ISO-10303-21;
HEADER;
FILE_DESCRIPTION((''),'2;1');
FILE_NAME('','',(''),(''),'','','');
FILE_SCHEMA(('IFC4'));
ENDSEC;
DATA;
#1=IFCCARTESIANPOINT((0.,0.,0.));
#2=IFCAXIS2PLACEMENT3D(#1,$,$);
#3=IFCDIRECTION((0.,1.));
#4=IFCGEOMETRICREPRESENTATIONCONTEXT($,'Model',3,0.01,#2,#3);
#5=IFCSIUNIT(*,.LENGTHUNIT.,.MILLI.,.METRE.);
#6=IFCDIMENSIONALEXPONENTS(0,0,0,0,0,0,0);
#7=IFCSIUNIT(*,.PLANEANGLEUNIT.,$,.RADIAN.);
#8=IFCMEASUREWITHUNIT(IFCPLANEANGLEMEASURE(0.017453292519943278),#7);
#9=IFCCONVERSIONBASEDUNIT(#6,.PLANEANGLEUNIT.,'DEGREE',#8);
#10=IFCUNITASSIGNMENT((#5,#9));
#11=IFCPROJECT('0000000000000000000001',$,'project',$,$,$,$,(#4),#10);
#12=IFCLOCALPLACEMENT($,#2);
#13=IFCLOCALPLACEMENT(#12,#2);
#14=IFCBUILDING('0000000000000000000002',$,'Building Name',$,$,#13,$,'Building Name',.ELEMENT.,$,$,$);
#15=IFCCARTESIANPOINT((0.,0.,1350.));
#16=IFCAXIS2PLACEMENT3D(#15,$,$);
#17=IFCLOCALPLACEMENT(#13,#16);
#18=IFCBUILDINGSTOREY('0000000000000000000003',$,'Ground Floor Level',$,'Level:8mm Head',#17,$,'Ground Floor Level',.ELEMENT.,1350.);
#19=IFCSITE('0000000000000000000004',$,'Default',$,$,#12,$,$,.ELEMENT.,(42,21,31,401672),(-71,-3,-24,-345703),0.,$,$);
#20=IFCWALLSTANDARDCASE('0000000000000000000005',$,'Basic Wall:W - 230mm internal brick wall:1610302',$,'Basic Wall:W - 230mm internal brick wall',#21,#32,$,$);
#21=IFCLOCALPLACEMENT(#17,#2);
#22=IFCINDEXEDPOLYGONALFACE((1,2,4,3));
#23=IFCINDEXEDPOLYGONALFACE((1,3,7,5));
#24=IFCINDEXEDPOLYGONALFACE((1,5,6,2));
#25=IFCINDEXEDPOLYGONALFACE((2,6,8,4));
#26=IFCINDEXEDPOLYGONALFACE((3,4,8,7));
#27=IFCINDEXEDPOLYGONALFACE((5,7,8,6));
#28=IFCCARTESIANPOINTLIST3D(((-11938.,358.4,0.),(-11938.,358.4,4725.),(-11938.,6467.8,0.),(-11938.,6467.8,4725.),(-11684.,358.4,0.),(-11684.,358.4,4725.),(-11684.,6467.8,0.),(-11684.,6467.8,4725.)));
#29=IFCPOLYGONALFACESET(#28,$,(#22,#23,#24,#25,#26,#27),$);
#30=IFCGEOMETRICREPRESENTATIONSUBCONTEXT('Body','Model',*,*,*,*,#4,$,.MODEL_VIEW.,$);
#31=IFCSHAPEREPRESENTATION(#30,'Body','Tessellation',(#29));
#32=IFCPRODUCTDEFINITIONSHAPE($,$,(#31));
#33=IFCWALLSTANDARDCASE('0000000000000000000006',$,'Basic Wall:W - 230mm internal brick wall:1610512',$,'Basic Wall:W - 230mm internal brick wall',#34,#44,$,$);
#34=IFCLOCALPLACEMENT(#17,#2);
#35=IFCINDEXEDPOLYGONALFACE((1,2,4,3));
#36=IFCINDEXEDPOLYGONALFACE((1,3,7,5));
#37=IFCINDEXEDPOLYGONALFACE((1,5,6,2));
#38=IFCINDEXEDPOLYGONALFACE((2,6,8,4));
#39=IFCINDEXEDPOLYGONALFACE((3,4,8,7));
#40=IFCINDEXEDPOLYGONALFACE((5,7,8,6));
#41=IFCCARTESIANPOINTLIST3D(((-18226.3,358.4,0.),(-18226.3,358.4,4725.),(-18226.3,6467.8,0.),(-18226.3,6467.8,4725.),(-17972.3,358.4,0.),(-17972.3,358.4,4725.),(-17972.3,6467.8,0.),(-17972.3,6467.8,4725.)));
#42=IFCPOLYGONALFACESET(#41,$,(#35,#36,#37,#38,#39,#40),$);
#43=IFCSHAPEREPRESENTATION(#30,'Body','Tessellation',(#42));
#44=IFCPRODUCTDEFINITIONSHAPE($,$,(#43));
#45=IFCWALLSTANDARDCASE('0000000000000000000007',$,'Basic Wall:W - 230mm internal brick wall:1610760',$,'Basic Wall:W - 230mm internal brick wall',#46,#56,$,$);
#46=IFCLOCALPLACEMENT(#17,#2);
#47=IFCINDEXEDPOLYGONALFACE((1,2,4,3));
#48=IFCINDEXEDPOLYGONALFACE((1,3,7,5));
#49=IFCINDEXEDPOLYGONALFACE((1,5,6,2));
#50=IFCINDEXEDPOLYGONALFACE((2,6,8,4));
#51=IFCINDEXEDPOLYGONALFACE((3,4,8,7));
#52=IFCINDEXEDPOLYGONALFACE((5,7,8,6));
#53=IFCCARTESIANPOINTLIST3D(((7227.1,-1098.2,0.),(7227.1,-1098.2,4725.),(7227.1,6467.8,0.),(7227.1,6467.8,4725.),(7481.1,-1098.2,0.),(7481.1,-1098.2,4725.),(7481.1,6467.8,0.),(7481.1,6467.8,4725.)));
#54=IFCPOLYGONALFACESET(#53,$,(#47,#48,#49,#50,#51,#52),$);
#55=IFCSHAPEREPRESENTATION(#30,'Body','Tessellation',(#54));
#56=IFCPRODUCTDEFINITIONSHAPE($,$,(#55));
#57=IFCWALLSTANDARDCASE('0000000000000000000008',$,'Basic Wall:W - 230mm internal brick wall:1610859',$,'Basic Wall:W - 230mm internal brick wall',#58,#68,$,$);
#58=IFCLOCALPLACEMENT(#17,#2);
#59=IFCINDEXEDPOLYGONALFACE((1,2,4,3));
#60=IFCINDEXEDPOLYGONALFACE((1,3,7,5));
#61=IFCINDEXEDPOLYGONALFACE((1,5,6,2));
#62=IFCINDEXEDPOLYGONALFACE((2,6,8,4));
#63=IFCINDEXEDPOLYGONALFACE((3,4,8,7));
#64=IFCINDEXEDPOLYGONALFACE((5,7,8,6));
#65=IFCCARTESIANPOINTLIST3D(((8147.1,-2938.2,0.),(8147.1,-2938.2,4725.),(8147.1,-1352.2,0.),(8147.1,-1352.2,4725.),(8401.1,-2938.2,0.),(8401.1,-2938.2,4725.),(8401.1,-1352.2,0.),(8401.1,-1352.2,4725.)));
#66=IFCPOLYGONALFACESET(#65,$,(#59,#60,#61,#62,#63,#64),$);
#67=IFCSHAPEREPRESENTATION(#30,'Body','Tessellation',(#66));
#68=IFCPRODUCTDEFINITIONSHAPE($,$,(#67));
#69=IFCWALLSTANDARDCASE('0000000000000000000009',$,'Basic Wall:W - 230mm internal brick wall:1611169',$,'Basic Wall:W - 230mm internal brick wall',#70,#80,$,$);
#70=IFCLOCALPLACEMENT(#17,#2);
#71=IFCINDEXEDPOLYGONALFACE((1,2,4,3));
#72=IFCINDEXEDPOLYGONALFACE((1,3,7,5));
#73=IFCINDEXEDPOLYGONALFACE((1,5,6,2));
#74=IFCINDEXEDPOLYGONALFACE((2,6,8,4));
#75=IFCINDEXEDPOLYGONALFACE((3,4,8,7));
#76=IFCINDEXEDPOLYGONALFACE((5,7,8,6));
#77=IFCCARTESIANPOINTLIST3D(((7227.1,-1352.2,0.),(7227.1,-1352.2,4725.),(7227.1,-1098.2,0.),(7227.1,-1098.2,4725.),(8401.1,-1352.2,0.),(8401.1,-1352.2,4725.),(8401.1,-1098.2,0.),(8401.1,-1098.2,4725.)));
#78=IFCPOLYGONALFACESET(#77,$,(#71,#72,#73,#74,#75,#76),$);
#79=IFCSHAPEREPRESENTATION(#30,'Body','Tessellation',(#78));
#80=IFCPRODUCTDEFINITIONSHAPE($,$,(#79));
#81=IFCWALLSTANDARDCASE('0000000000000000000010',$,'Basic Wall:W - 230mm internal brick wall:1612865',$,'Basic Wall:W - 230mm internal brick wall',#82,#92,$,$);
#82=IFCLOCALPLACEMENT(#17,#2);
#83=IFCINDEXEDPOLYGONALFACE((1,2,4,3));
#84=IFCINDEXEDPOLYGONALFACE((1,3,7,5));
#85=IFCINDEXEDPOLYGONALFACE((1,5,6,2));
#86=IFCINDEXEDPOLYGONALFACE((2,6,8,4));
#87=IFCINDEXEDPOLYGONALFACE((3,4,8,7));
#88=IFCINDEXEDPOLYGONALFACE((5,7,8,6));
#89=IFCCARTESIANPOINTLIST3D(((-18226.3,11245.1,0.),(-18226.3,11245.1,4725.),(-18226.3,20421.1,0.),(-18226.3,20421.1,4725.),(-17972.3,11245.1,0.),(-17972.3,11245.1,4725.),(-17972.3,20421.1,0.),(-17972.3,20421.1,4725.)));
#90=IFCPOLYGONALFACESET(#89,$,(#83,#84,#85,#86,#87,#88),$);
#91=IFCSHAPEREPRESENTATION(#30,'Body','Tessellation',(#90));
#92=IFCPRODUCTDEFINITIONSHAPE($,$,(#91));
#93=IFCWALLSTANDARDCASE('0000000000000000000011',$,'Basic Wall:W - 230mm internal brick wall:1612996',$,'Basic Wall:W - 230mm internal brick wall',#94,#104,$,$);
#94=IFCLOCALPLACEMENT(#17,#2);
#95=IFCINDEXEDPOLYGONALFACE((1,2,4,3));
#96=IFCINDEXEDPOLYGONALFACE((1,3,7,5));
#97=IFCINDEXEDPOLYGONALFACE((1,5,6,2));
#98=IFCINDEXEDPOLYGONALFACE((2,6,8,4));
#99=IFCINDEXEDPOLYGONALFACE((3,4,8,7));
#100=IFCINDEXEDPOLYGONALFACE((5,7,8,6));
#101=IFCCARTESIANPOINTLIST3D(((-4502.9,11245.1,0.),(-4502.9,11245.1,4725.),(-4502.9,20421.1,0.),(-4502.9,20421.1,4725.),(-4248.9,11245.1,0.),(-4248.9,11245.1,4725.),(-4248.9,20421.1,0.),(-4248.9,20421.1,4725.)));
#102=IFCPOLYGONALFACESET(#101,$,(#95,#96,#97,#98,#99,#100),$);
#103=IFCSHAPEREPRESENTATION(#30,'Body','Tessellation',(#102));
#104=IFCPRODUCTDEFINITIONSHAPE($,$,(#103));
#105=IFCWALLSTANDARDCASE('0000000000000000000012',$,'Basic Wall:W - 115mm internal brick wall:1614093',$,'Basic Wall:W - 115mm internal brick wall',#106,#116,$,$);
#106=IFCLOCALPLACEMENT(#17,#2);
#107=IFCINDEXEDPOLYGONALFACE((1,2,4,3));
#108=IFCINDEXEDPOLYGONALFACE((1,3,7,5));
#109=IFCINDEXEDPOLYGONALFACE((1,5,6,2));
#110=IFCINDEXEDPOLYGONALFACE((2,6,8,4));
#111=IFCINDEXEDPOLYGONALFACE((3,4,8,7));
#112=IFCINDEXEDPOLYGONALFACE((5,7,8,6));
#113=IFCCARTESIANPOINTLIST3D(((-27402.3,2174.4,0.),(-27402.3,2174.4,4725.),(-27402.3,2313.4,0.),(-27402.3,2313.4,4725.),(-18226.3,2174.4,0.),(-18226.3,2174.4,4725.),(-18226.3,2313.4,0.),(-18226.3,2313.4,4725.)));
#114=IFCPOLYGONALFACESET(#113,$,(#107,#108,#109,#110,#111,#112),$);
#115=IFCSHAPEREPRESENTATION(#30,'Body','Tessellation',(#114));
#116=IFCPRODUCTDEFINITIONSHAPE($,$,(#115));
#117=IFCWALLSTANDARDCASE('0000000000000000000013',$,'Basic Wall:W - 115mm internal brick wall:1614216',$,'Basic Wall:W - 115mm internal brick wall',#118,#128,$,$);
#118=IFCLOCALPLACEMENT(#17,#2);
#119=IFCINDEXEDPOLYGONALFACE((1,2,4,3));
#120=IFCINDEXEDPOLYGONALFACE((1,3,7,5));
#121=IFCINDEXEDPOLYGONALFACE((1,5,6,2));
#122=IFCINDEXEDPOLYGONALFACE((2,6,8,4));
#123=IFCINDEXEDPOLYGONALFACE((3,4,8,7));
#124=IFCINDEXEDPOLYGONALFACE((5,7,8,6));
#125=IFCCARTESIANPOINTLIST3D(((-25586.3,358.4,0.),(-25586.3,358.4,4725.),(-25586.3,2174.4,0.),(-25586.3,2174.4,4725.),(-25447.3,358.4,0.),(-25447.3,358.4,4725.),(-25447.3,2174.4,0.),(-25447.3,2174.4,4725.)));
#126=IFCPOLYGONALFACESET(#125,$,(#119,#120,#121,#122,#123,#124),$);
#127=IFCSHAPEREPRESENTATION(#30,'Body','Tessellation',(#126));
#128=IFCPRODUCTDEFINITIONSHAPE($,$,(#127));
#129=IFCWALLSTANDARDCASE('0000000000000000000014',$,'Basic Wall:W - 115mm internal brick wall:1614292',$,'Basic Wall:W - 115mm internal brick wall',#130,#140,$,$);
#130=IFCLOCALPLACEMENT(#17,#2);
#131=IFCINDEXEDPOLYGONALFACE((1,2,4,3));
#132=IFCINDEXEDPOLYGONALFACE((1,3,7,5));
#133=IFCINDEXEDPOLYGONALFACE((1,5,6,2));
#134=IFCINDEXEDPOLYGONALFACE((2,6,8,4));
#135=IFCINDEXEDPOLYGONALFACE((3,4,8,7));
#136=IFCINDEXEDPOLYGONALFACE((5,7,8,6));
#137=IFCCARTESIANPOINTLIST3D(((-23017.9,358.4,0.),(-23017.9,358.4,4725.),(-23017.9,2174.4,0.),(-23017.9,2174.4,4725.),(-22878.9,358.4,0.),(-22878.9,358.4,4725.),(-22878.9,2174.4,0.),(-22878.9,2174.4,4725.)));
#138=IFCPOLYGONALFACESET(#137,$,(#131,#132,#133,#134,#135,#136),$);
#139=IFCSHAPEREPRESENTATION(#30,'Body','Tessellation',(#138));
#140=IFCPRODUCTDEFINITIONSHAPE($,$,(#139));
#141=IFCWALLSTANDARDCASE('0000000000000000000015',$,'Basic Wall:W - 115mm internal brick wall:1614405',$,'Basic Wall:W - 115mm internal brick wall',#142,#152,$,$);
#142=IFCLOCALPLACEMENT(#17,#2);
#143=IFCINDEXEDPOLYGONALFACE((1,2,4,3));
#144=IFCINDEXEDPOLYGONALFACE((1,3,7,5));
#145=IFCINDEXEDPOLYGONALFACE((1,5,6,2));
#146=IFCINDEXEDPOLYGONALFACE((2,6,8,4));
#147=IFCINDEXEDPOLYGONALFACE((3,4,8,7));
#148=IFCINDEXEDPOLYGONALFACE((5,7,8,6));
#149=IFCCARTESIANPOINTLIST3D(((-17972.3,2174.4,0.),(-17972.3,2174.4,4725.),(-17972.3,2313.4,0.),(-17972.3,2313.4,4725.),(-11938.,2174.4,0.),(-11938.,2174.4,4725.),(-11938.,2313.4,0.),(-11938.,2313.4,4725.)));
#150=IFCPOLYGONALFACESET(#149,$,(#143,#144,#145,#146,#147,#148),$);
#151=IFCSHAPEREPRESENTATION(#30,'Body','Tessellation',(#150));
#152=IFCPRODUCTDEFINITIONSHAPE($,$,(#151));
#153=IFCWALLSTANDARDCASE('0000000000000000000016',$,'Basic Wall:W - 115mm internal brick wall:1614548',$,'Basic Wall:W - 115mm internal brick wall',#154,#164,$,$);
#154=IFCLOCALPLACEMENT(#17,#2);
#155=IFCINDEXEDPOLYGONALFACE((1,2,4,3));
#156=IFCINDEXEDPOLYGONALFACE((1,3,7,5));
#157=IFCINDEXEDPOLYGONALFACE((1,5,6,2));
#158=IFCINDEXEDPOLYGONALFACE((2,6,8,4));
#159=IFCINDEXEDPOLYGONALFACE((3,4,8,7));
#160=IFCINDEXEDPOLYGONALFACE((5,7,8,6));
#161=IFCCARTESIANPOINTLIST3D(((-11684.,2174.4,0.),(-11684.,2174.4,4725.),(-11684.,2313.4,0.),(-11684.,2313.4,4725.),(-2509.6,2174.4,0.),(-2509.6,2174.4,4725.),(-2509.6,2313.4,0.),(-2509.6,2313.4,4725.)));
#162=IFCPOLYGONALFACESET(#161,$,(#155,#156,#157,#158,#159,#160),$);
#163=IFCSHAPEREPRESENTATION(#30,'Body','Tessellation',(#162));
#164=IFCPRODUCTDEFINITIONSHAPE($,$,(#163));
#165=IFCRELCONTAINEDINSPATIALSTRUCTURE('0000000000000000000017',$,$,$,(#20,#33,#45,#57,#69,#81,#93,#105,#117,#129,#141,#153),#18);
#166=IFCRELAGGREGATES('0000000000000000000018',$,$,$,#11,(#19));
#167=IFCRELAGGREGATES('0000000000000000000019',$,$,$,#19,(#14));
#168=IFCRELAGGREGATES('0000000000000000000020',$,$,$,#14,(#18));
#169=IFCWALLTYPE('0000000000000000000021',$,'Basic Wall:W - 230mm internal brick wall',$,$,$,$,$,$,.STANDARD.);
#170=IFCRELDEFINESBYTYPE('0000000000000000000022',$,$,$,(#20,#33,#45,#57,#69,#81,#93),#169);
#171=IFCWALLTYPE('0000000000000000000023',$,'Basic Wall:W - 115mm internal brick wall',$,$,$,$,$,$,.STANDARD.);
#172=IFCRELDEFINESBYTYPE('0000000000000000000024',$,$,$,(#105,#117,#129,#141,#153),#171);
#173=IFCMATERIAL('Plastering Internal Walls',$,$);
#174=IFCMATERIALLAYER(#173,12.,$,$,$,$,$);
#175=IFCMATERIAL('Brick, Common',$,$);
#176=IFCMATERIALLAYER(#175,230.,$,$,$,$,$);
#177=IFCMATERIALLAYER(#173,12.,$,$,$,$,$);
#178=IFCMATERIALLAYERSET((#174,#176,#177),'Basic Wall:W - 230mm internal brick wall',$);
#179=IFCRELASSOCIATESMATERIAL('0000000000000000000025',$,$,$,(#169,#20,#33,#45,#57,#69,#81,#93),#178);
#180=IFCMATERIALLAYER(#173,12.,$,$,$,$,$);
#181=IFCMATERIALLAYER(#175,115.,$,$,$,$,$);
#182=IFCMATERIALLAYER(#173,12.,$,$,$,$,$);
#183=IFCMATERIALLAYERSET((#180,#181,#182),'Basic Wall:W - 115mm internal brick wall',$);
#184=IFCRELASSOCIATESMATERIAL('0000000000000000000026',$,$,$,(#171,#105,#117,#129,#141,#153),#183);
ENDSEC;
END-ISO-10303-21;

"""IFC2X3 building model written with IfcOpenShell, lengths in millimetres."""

from ifc_helpers import new_model, entity, si_unit, converted_unit, direction, frame, frame_2d, origin, place, context, subcontext, project, spatial, rectangle, extrude, material, layer, layer_set, layer_usage, type_object, element, save


model = new_model("IFC2X3")

# Units and contexts
model_context = context("Model", 3, precision=0.01, world=origin(), true_north=direction((0.0, 1.0)))
body_context = subcontext(model_context, "Body", "Model", "MODEL_VIEW")
ifc_project = project(units=[si_unit("LENGTHUNIT", "METRE", prefix="MILLI"), converted_unit("PLANEANGLEUNIT", "DEGREE", entity("IfcPlaneAngleMeasure", 0.017453292519943278), si_unit("PLANEANGLEUNIT", "RADIAN"), dimensions=[0, 0, 0, 0, 0, 0, 0])], contexts=[model_context])

# Site, building, storey
site_placement = place(None, origin())
site = spatial("IfcSite", under=ifc_project, at=site_placement, Name="Default", CompositionType="ELEMENT", RefLatitude=(42, 21, 31, 401672), RefLongitude=(-71, -3, -24, -345703), RefElevation=0.0)
building_placement = place(site_placement, origin())
building = spatial("IfcBuilding", under=site, at=building_placement, Name="Building Name", LongName="Building Name", CompositionType="ELEMENT")
storey_placement = place(building_placement, frame((0.0, 0.0, 1350.0)))
storey = spatial("IfcBuildingStorey", under=building, at=storey_placement, Name="Ground Floor Level", ObjectType="Level:8mm Head", LongName="Ground Floor Level", CompositionType="ELEMENT", Elevation=1350.0)

# Walls
ifc_material_1 = material(Name="Brick, Common")
ifc_material_2 = material(Name="Plastering Internal Walls")
ifc_layer_1 = layer(ifc_material_2, 12.0)
ifc_layer_2 = layer(ifc_material_1, 230.0)
ifc_layer_3 = layer(ifc_material_2, 12.0)
ifc_layer_set_1 = layer_set([ifc_layer_1, ifc_layer_2, ifc_layer_3], Name="Basic Wall:W - 230mm internal brick wall")
wall_type_1 = type_object("IfcWallType", Name="Basic Wall:W - 230mm internal brick wall", PredefinedType="STANDARD", material=ifc_layer_set_1)
ifc_layer_usage_1 = layer_usage(ifc_layer_set_1, "AXIS2", "NEGATIVE", 127.0)
wall_1_placement = place(storey_placement, frame((-11811.0, 358.4, 0.0), z_axis=(0.0, 0.0, 1.0), x_axis=(0.0, 1.0, 0.0)))
element("IfcWallStandardCase", 1, at=wall_1_placement, inside=storey, type_object=wall_type_1, material=ifc_layer_usage_1, Name="Basic Wall:W - 230mm internal brick wall:1610302", ObjectType="Basic Wall:W - 230mm internal brick wall", context=body_context, shape_type="SweptSolid", body=[
    extrude(rectangle(XDim=6109.3, YDim=254.0, at=frame_2d((3054.7, 0.0), x_axis=(-1.0, 0.0))), origin(), (0.0, 0.0, 1.0), 4725.0),
])
ifc_layer_usage_2 = layer_usage(ifc_layer_set_1, "AXIS2", "NEGATIVE", 127.0)
wall_2_placement = place(storey_placement, frame((-18099.3, 358.4, 0.0), z_axis=(0.0, 0.0, 1.0), x_axis=(0.0, 1.0, 0.0)))
element("IfcWallStandardCase", 2, at=wall_2_placement, inside=storey, type_object=wall_type_1, material=ifc_layer_usage_2, Name="Basic Wall:W - 230mm internal brick wall:1610512", ObjectType="Basic Wall:W - 230mm internal brick wall", context=body_context, shape_type="SweptSolid", body=[
    extrude(rectangle(XDim=6109.3, YDim=254.0, at=frame_2d((3054.7, 0.0), x_axis=(-1.0, 0.0))), origin(), (0.0, 0.0, 1.0), 4725.0),
])
ifc_layer_usage_3 = layer_usage(ifc_layer_set_1, "AXIS2", "NEGATIVE", 127.0)
wall_3_placement = place(storey_placement, frame((7354.1, 6467.8, 0.0), z_axis=(0.0, 0.0, 1.0), x_axis=(0.0, -1.0, 0.0)))
element("IfcWallStandardCase", 3, at=wall_3_placement, inside=storey, type_object=wall_type_1, material=ifc_layer_usage_3, Name="Basic Wall:W - 230mm internal brick wall:1610760", ObjectType="Basic Wall:W - 230mm internal brick wall", context=body_context, shape_type="SweptSolid", body=[
    extrude(rectangle(XDim=7566.0, YDim=254.0, at=frame_2d((3783.0, 0.0), x_axis=(-1.0, 0.0))), origin(), (0.0, 0.0, 1.0), 4725.0),
])
ifc_layer_usage_4 = layer_usage(ifc_layer_set_1, "AXIS2", "NEGATIVE", 127.0)
wall_4_placement = place(storey_placement, frame((8274.1, -1352.2, 0.0), z_axis=(0.0, 0.0, 1.0), x_axis=(0.0, -1.0, 0.0)))
element("IfcWallStandardCase", 4, at=wall_4_placement, inside=storey, type_object=wall_type_1, material=ifc_layer_usage_4, Name="Basic Wall:W - 230mm internal brick wall:1610859", ObjectType="Basic Wall:W - 230mm internal brick wall", context=body_context, shape_type="SweptSolid", body=[
    extrude(rectangle(XDim=1586.0, YDim=254.0, at=frame_2d((793.0, 0.0), x_axis=(-1.0, 0.0))), origin(), (0.0, 0.0, 1.0), 4725.0),
])
ifc_layer_usage_5 = layer_usage(ifc_layer_set_1, "AXIS2", "NEGATIVE", 127.0)
wall_5_placement = place(storey_placement, frame((8401.1, -1225.2, 0.0), z_axis=(0.0, 0.0, 1.0), x_axis=(-1.0, 0.0, 0.0)))
element("IfcWallStandardCase", 5, at=wall_5_placement, inside=storey, type_object=wall_type_1, material=ifc_layer_usage_5, Name="Basic Wall:W - 230mm internal brick wall:1611169", ObjectType="Basic Wall:W - 230mm internal brick wall", context=body_context, shape_type="SweptSolid", body=[
    extrude(rectangle(XDim=1174.0, YDim=254.0, at=frame_2d((587.0, 0.0), x_axis=(-1.0, 0.0))), origin(), (0.0, 0.0, 1.0), 4725.0),
])
ifc_layer_usage_6 = layer_usage(ifc_layer_set_1, "AXIS2", "NEGATIVE", 127.0)
wall_6_placement = place(storey_placement, frame((-18099.3, 11245.1, 0.0), z_axis=(0.0, 0.0, 1.0), x_axis=(0.0, 1.0, 0.0)))
element("IfcWallStandardCase", 6, at=wall_6_placement, inside=storey, type_object=wall_type_1, material=ifc_layer_usage_6, Name="Basic Wall:W - 230mm internal brick wall:1612865", ObjectType="Basic Wall:W - 230mm internal brick wall", context=body_context, shape_type="SweptSolid", body=[
    extrude(rectangle(XDim=9176.0, YDim=254.0, at=frame_2d((4588.0, 0.0), x_axis=(-1.0, 0.0))), origin(), (0.0, 0.0, 1.0), 4725.0),
])
ifc_layer_usage_7 = layer_usage(ifc_layer_set_1, "AXIS2", "NEGATIVE", 127.0)
wall_7_placement = place(storey_placement, frame((-4375.9, 11245.1, 0.0), z_axis=(0.0, 0.0, 1.0), x_axis=(0.0, 1.0, 0.0)))
element("IfcWallStandardCase", 7, at=wall_7_placement, inside=storey, type_object=wall_type_1, material=ifc_layer_usage_7, Name="Basic Wall:W - 230mm internal brick wall:1612996", ObjectType="Basic Wall:W - 230mm internal brick wall", context=body_context, shape_type="SweptSolid", body=[
    extrude(rectangle(XDim=9176.0, YDim=254.0, at=frame_2d((4588.0, 0.0), x_axis=(-1.0, 0.0))), origin(), (0.0, 0.0, 1.0), 4725.0),
])
ifc_layer_4 = layer(ifc_material_2, 12.0)
ifc_layer_5 = layer(ifc_material_1, 115.0)
ifc_layer_6 = layer(ifc_material_2, 12.0)
ifc_layer_set_2 = layer_set([ifc_layer_4, ifc_layer_5, ifc_layer_6], Name="Basic Wall:W - 115mm internal brick wall")
ifc_layer_usage_8 = layer_usage(ifc_layer_set_2, "AXIS2", "NEGATIVE", 69.5)
wall_type_2 = type_object("IfcWallType", Name="Basic Wall:W - 115mm internal brick wall", PredefinedType="STANDARD", material=ifc_layer_set_2)
wall_8_placement = place(storey_placement, frame((-18226.3, 2243.9, 0.0), z_axis=(0.0, 0.0, 1.0), x_axis=(-1.0, 0.0, 0.0)))
element("IfcWallStandardCase", 8, at=wall_8_placement, inside=storey, type_object=wall_type_2, material=ifc_layer_usage_8, Name="Basic Wall:W - 115mm internal brick wall:1614093", ObjectType="Basic Wall:W - 115mm internal brick wall", context=body_context, shape_type="SweptSolid", body=[
    extrude(rectangle(XDim=9176.0, YDim=139.0, at=frame_2d((4588.0, 0.0), x_axis=(-1.0, 0.0))), origin(), (0.0, 0.0, 1.0), 4725.0),
])
ifc_layer_usage_9 = layer_usage(ifc_layer_set_2, "AXIS2", "NEGATIVE", 69.5)
wall_9_placement = place(storey_placement, frame((-25516.8, 358.4, 0.0), z_axis=(0.0, 0.0, 1.0), x_axis=(0.0, 1.0, 0.0)))
element("IfcWallStandardCase", 9, at=wall_9_placement, inside=storey, type_object=wall_type_2, material=ifc_layer_usage_9, Name="Basic Wall:W - 115mm internal brick wall:1614216", ObjectType="Basic Wall:W - 115mm internal brick wall", context=body_context, shape_type="SweptSolid", body=[
    extrude(rectangle(XDim=1816.0, YDim=139.0, at=frame_2d((908.0, 0.0), x_axis=(-1.0, 0.0))), origin(), (0.0, 0.0, 1.0), 4725.0),
])
ifc_layer_usage_10 = layer_usage(ifc_layer_set_2, "AXIS2", "NEGATIVE", 69.5)
wall_10_placement = place(storey_placement, frame((-22948.4, 358.4, 0.0), z_axis=(0.0, 0.0, 1.0), x_axis=(0.0, 1.0, 0.0)))
element("IfcWallStandardCase", 10, at=wall_10_placement, inside=storey, type_object=wall_type_2, material=ifc_layer_usage_10, Name="Basic Wall:W - 115mm internal brick wall:1614292", ObjectType="Basic Wall:W - 115mm internal brick wall", context=body_context, shape_type="SweptSolid", body=[
    extrude(rectangle(XDim=1816.0, YDim=139.0, at=frame_2d((908.0, 0.0), x_axis=(-1.0, 0.0))), origin(), (0.0, 0.0, 1.0), 4725.0),
])
ifc_layer_usage_11 = layer_usage(ifc_layer_set_2, "AXIS2", "NEGATIVE", 69.5)
wall_11_placement = place(storey_placement, frame((-11938.0, 2243.9, 0.0), z_axis=(0.0, 0.0, 1.0), x_axis=(-1.0, 0.0, 0.0)))
element("IfcWallStandardCase", 11, at=wall_11_placement, inside=storey, type_object=wall_type_2, material=ifc_layer_usage_11, Name="Basic Wall:W - 115mm internal brick wall:1614405", ObjectType="Basic Wall:W - 115mm internal brick wall", context=body_context, shape_type="SweptSolid", body=[
    extrude(rectangle(XDim=6034.2, YDim=139.0, at=frame_2d((3017.1, 0.0), x_axis=(-1.0, 0.0))), origin(), (0.0, 0.0, 1.0), 4725.0),
])
ifc_layer_usage_12 = layer_usage(ifc_layer_set_2, "AXIS2", "NEGATIVE", 69.5)
wall_12_placement = place(storey_placement, frame((-2509.6, 2243.9, 0.0), z_axis=(0.0, 0.0, 1.0), x_axis=(-1.0, 0.0, 0.0)))
element("IfcWallStandardCase", 12, at=wall_12_placement, inside=storey, type_object=wall_type_2, material=ifc_layer_usage_12, Name="Basic Wall:W - 115mm internal brick wall:1614548", ObjectType="Basic Wall:W - 115mm internal brick wall", context=body_context, shape_type="SweptSolid", body=[
    extrude(rectangle(XDim=9174.4, YDim=139.0, at=frame_2d((4587.2, 0.0), x_axis=(-1.0, 0.0))), origin(), (0.0, 0.0, 1.0), 4725.0),
])

save(model, "model.ifc")
